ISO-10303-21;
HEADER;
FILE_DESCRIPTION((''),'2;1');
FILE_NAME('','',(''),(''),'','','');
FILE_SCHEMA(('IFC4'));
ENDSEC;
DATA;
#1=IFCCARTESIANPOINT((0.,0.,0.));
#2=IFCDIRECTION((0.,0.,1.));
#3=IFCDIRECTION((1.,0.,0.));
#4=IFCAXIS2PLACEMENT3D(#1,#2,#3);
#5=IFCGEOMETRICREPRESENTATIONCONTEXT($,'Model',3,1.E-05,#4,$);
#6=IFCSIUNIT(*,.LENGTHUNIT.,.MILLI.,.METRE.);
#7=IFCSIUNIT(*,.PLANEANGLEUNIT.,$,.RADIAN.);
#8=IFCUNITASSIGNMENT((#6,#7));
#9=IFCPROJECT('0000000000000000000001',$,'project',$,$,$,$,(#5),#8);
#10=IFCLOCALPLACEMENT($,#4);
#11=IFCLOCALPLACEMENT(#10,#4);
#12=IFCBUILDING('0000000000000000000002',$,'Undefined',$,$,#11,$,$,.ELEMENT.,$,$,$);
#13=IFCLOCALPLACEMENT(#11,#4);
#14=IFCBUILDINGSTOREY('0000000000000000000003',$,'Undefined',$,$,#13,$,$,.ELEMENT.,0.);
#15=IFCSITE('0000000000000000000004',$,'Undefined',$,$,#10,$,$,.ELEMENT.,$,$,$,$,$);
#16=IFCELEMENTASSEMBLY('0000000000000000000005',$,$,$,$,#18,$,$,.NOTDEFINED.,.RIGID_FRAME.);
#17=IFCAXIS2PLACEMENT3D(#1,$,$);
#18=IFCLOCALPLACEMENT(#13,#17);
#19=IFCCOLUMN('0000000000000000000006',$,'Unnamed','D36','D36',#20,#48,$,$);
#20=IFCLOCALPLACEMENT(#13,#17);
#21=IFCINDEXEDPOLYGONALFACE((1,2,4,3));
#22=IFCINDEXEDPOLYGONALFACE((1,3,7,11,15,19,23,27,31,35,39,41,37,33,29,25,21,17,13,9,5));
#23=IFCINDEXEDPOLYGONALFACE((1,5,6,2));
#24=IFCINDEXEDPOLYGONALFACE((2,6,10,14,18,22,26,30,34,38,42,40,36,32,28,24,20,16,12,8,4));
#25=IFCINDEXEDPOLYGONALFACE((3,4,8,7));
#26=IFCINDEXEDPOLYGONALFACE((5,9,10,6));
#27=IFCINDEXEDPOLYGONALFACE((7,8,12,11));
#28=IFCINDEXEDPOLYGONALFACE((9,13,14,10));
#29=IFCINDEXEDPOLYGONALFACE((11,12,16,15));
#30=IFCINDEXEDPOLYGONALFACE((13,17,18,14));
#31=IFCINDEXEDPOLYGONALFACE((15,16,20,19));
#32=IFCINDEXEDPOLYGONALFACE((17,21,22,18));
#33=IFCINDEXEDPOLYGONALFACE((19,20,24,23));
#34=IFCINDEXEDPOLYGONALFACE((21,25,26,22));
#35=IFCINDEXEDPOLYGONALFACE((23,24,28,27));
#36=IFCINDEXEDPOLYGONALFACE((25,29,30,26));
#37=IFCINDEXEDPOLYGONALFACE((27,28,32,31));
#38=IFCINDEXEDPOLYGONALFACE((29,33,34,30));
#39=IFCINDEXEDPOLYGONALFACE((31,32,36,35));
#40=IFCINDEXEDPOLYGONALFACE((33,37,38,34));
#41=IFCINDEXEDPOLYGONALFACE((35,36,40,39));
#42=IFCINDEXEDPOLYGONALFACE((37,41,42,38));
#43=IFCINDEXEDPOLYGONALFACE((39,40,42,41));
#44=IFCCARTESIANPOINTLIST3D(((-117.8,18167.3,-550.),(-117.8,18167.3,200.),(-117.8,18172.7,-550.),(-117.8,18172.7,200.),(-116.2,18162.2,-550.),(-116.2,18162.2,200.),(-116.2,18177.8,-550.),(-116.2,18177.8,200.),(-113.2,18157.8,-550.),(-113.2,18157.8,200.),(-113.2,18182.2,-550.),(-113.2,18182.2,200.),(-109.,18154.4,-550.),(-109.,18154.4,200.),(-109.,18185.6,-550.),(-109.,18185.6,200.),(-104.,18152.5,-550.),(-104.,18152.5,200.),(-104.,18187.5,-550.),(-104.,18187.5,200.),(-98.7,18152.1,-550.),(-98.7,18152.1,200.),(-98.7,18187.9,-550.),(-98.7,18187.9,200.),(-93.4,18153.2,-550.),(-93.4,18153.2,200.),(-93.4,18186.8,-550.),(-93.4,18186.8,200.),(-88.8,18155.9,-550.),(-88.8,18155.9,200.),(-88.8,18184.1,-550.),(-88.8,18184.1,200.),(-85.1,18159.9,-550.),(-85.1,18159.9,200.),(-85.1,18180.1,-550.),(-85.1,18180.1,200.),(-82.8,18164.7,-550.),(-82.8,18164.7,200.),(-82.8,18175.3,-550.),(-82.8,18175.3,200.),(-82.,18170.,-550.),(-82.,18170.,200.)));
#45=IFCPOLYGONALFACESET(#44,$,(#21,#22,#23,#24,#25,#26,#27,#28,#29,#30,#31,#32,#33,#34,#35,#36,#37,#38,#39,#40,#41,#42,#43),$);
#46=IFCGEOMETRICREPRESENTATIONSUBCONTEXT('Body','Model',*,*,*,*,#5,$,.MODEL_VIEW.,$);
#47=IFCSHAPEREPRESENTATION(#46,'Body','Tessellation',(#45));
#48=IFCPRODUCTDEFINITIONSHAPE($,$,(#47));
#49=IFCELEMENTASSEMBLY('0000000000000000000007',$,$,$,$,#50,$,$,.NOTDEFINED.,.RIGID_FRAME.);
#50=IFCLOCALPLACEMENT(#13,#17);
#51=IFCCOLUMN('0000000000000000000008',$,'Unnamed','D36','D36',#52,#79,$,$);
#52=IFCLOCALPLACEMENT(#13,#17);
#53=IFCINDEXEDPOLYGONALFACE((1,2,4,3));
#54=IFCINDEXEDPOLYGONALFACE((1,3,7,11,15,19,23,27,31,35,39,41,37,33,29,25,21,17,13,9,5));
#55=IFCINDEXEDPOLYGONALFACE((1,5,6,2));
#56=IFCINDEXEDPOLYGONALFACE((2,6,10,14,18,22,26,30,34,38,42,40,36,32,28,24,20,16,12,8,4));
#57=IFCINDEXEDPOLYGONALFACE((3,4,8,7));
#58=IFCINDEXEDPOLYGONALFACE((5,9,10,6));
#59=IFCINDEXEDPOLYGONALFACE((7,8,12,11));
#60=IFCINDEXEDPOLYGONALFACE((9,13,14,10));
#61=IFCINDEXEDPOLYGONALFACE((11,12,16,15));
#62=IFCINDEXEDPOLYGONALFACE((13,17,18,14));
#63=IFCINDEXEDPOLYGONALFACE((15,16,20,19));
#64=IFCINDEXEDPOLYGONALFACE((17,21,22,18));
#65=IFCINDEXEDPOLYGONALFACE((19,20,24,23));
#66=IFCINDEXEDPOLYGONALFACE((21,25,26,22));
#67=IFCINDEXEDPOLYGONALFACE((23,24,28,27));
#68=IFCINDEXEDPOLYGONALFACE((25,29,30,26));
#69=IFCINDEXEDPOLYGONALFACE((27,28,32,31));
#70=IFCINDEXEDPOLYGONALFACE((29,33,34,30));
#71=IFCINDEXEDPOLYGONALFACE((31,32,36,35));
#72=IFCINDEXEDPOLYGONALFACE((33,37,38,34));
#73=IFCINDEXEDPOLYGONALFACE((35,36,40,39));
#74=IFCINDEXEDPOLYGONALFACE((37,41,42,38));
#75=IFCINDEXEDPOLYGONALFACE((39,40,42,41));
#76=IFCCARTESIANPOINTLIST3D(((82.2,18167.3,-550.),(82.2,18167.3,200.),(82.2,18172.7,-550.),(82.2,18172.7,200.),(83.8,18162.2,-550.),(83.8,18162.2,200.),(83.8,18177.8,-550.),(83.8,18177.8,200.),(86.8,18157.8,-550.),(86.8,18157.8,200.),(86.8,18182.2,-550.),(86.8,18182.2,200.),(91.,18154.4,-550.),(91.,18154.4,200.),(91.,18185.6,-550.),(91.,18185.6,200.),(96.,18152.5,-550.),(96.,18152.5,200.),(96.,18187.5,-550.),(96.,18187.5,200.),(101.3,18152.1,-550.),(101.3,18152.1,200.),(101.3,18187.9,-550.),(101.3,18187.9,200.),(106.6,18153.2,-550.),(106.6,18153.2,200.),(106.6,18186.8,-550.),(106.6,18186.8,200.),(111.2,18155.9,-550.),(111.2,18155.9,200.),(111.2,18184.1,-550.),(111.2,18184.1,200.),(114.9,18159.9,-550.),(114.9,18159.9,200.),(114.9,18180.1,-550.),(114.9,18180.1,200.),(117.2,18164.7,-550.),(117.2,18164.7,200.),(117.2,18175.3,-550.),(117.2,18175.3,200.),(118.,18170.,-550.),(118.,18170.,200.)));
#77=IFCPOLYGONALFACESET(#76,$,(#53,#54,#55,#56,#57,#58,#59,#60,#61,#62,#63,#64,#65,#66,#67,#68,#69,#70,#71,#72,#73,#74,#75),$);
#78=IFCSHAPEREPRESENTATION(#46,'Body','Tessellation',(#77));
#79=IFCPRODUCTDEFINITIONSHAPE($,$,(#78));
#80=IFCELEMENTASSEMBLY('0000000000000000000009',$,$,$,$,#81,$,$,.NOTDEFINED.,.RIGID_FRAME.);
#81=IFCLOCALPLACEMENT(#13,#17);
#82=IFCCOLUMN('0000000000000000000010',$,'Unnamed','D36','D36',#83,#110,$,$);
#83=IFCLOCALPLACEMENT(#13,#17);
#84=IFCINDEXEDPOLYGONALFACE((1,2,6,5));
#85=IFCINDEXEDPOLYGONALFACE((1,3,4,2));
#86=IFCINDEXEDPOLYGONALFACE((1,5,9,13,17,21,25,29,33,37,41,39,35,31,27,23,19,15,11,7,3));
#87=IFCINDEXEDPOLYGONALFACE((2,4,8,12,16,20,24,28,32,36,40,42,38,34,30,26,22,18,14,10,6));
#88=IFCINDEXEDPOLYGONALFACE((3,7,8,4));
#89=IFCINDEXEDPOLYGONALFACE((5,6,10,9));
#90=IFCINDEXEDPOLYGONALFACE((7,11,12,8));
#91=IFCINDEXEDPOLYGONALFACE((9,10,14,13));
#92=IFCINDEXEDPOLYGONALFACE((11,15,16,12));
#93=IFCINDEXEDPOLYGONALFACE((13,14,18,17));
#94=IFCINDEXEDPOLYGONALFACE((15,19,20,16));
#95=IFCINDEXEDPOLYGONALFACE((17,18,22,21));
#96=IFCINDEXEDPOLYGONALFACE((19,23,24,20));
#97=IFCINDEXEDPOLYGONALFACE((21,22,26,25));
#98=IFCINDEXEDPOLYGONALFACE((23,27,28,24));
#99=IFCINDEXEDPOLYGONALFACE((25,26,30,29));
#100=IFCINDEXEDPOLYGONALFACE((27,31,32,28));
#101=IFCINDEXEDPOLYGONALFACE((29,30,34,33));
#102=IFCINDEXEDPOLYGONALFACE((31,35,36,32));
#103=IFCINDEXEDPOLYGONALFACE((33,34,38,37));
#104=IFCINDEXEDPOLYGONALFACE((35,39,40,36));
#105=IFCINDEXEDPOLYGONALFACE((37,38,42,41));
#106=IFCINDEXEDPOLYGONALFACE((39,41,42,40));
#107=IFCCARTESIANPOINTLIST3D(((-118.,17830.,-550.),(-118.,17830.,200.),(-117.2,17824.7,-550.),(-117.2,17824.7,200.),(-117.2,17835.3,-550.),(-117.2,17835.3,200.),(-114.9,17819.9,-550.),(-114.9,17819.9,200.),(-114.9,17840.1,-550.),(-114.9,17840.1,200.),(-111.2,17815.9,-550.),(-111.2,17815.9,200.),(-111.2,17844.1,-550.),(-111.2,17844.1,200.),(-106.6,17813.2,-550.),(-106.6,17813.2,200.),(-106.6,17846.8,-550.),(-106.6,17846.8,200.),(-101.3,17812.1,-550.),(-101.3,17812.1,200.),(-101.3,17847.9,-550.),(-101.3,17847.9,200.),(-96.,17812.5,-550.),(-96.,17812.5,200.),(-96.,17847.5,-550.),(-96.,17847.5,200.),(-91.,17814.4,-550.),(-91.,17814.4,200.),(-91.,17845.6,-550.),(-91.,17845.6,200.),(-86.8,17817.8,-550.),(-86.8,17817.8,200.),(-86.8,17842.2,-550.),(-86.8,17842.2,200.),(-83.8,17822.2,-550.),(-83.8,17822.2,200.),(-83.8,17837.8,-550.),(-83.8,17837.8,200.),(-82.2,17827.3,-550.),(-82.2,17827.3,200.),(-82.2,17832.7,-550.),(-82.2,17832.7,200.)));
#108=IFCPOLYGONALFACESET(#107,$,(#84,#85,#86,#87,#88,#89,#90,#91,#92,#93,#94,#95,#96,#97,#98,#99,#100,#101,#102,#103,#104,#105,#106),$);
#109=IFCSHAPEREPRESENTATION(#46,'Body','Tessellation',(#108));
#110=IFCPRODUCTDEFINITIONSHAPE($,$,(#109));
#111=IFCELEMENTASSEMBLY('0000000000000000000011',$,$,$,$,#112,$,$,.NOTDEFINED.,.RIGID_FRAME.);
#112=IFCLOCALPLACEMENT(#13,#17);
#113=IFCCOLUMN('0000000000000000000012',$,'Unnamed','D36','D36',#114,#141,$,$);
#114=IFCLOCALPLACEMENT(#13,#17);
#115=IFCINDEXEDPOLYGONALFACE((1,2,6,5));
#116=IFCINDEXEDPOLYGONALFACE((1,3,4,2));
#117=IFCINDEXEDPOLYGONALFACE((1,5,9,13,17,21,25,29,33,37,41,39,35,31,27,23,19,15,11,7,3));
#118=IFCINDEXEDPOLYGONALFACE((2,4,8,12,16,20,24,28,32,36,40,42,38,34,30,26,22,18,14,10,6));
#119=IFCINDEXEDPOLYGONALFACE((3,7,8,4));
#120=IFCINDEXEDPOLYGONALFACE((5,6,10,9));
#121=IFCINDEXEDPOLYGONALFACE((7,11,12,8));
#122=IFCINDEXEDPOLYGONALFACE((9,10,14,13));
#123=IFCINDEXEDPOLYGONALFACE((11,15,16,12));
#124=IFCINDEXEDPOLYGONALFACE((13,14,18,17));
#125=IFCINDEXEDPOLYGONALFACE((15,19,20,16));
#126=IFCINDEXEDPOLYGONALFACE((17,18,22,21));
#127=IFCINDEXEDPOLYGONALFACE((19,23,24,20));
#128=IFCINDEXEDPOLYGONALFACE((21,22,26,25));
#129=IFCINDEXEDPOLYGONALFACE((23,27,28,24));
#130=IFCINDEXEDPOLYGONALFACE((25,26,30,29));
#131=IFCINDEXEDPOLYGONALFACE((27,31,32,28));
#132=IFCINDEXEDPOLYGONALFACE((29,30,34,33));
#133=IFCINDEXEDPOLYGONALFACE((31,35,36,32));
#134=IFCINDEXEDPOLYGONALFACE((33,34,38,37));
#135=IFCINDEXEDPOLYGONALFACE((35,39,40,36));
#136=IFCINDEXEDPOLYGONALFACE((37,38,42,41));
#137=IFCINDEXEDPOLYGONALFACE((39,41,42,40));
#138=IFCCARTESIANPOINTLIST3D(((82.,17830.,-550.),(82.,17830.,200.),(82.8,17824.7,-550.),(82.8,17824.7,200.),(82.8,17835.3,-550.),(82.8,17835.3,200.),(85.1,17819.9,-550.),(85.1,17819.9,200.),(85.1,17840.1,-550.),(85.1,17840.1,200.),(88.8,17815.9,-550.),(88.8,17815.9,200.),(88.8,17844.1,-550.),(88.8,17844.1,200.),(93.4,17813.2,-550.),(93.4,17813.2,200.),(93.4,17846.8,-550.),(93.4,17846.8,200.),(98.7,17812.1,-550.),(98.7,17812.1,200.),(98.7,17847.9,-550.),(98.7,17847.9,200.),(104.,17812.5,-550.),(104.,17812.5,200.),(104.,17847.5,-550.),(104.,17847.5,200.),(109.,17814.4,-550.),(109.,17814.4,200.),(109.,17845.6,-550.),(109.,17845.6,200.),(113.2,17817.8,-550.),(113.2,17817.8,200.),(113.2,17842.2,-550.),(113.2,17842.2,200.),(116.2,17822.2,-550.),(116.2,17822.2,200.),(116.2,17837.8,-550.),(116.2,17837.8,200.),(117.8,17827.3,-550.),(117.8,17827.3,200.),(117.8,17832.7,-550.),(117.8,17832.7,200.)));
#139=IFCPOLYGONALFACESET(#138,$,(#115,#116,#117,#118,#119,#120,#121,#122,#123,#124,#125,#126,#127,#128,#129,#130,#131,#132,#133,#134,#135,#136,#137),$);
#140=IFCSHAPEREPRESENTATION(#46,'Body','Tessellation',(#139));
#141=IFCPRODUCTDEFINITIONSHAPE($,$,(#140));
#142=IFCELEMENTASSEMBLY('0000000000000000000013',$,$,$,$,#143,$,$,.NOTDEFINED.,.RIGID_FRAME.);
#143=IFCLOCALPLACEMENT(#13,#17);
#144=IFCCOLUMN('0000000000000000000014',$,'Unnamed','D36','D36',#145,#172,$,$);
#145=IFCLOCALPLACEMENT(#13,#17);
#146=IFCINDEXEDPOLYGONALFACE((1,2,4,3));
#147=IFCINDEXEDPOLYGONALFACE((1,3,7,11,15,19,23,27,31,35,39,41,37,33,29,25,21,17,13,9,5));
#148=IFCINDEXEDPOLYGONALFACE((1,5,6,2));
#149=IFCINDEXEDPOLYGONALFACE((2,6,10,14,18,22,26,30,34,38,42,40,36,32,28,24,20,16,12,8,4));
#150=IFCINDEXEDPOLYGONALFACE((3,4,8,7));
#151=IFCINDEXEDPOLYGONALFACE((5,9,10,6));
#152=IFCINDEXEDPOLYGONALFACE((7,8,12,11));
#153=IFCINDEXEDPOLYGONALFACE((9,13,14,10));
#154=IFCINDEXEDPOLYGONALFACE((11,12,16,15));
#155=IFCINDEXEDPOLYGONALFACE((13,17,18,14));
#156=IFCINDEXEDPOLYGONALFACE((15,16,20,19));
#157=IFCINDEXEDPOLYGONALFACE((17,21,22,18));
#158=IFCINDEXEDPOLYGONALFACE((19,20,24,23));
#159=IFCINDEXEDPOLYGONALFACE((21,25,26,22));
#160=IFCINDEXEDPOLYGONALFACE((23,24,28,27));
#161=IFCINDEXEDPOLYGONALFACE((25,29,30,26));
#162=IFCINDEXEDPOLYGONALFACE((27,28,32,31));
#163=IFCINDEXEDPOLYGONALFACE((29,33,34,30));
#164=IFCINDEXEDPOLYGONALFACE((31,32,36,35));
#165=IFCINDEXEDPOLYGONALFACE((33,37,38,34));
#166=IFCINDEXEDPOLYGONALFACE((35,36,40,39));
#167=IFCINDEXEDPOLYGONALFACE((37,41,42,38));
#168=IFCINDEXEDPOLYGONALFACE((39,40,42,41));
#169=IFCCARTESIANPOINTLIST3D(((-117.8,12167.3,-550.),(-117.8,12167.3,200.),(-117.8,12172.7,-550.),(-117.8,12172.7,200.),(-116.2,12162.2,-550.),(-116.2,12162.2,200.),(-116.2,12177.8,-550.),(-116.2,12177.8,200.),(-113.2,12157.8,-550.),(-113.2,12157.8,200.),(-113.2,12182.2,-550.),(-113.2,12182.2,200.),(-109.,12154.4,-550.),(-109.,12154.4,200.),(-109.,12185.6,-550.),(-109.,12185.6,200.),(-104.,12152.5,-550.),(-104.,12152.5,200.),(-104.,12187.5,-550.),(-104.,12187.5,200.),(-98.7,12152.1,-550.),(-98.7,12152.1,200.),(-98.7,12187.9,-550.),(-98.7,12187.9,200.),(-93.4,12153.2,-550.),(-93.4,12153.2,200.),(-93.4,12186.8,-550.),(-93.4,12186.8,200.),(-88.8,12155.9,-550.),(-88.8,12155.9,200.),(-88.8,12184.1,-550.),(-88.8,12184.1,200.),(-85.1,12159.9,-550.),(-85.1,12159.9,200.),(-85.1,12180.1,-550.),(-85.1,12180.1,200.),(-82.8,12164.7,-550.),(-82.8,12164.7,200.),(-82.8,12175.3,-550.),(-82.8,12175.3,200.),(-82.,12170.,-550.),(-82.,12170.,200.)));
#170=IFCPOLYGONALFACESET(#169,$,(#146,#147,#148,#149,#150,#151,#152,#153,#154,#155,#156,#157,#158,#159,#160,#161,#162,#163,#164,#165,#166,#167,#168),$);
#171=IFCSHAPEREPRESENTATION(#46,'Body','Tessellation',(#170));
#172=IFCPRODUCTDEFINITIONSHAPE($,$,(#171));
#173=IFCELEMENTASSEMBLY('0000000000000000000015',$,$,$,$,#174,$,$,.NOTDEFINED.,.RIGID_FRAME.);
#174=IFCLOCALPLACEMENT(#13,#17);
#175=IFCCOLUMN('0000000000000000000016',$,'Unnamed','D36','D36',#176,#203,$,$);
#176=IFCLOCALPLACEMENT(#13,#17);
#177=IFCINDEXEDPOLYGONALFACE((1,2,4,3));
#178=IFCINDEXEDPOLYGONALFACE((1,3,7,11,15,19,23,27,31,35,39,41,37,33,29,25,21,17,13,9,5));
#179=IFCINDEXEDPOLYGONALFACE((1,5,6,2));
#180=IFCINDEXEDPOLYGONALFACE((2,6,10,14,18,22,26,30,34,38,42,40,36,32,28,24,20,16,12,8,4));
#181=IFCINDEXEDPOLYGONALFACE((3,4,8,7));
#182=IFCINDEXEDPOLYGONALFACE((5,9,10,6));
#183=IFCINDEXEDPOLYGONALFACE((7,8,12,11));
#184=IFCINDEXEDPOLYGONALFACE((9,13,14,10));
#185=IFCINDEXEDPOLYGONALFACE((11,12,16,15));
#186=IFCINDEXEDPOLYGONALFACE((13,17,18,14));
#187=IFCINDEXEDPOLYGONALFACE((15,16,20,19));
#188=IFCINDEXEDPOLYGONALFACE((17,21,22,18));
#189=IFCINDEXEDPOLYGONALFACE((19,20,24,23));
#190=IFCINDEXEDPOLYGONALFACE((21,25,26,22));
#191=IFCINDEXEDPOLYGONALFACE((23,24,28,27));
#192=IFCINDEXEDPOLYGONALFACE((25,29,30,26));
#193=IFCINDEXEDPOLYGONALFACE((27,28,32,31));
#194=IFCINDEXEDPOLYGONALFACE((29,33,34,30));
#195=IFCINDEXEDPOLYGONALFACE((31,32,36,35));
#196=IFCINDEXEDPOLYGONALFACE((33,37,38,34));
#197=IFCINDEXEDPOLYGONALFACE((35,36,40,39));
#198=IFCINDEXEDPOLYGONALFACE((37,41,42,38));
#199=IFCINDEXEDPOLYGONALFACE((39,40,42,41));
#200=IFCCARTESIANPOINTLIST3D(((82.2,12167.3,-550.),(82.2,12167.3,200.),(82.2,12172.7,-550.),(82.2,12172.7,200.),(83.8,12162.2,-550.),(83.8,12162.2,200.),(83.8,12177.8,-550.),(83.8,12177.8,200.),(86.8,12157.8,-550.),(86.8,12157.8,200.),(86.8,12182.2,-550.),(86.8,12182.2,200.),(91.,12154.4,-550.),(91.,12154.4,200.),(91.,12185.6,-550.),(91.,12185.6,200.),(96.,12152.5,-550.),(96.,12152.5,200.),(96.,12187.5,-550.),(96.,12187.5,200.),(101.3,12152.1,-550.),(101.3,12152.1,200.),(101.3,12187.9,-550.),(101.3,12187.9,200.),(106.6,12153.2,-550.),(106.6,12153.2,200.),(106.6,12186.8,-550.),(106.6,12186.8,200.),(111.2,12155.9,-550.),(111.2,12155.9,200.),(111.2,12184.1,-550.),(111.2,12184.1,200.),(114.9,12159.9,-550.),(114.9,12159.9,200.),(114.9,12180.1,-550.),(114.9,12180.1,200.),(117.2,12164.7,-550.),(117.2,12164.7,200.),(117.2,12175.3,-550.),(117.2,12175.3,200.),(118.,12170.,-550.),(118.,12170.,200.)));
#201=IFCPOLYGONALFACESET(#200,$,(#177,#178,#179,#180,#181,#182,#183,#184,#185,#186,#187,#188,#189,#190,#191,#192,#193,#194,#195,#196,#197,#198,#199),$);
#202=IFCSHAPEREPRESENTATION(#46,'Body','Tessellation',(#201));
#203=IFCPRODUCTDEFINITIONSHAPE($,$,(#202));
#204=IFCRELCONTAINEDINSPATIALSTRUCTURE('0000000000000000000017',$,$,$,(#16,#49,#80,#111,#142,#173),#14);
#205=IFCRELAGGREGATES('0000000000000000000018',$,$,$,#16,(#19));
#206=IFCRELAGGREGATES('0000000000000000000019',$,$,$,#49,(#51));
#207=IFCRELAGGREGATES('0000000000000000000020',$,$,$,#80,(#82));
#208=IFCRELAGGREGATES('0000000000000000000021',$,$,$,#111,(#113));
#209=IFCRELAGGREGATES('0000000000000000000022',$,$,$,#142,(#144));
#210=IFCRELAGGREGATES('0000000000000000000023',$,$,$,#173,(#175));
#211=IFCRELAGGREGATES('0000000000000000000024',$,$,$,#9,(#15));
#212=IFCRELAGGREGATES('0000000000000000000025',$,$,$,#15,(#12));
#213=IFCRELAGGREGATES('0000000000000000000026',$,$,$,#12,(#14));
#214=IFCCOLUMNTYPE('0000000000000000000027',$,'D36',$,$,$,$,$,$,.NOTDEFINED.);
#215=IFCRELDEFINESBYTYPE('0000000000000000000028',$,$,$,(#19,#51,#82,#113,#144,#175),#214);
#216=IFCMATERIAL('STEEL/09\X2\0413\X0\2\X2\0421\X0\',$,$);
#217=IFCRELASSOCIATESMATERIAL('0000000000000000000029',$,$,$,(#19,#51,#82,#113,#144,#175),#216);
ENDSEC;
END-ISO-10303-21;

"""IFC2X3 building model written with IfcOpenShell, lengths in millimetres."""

from ifc_helpers import new_model, si_unit, frame, origin_with_axes, origin_2d_with_axis, place, context, subcontext, project, spatial, circle, extrude, material, type_object, element, aggregate, save


model = new_model("IFC2X3")

# Units and contexts
model_context = context("Model", 3, precision=1e-05, world=origin_with_axes())
body_context = subcontext(model_context, "Body", "Model", "MODEL_VIEW")
ifc_project = project(units=[si_unit("LENGTHUNIT", "METRE", prefix="MILLI"), si_unit("PLANEANGLEUNIT", "RADIAN")], contexts=[model_context])

# Site, building, storey
site_placement = place(None, origin_with_axes())
site = spatial("IfcSite", under=ifc_project, at=site_placement, Name="Undefined", CompositionType="ELEMENT")
building_placement = place(site_placement, origin_with_axes())
building = spatial("IfcBuilding", under=site, at=building_placement, Name="Undefined", CompositionType="ELEMENT")
storey_placement = place(building_placement, origin_with_axes())
storey = spatial("IfcBuildingStorey", under=building, at=storey_placement, Name="Undefined", CompositionType="ELEMENT", Elevation=0.0)

# Element assemblies, columns
assembly_1_placement = place(storey_placement, origin_with_axes())
assembly_1 = element("IfcElementAssembly", 1, at=assembly_1_placement, inside=storey, AssemblyPlace="NOTDEFINED", PredefinedType="RIGID_FRAME")
ifc_material_1 = material(Name="STEEL/09Г2С")
column_type_1 = type_object("IfcColumnType", Name="D36", PredefinedType="NOTDEFINED")
column_1_placement = place(assembly_1_placement, frame((-100.0, 18170.0, -550.0), z_axis=(0.0, 0.0, 1.0), x_axis=(0.0, -1.0, 0.0)))
column_1 = element("IfcColumn", 2, at=column_1_placement, type_object=column_type_1, material=ifc_material_1, Name="Unnamed", Description="D36", ObjectType="D36", context=body_context, shape_type="SweptSolid", body=[
    extrude(circle(Radius=18.0, at=origin_2d_with_axis()), frame((0.0, 0.0, 750.0), z_axis=(0.0, 0.0, -1.0), x_axis=(0.0, 1.0, 0.0)), (0.0, 0.0, 1.0), 750.0),
])
aggregate(assembly_1, [column_1])
assembly_2_placement = place(storey_placement, origin_with_axes())
assembly_2 = element("IfcElementAssembly", 3, at=assembly_2_placement, inside=storey, AssemblyPlace="NOTDEFINED", PredefinedType="RIGID_FRAME")
column_2_placement = place(assembly_2_placement, frame((100.0, 18170.0, -550.0), z_axis=(0.0, 0.0, 1.0), x_axis=(0.0, -1.0, 0.0)))
column_2 = element("IfcColumn", 4, at=column_2_placement, type_object=column_type_1, material=ifc_material_1, Name="Unnamed", Description="D36", ObjectType="D36", context=body_context, shape_type="SweptSolid", body=[
    extrude(circle(Radius=18.0, at=origin_2d_with_axis()), frame((0.0, 0.0, 750.0), z_axis=(0.0, 0.0, -1.0), x_axis=(0.0, 1.0, 0.0)), (0.0, 0.0, 1.0), 750.0),
])
aggregate(assembly_2, [column_2])
assembly_3_placement = place(storey_placement, origin_with_axes())
assembly_3 = element("IfcElementAssembly", 5, at=assembly_3_placement, inside=storey, AssemblyPlace="NOTDEFINED", PredefinedType="RIGID_FRAME")
column_3_placement = place(assembly_3_placement, frame((-100.0, 17830.0, -550.0), z_axis=(0.0, 0.0, 1.0), x_axis=(0.0, 1.0, 0.0)))
column_3 = element("IfcColumn", 6, at=column_3_placement, type_object=column_type_1, material=ifc_material_1, Name="Unnamed", Description="D36", ObjectType="D36", context=body_context, shape_type="SweptSolid", body=[
    extrude(circle(Radius=18.0, at=origin_2d_with_axis()), frame((0.0, 0.0, 750.0), z_axis=(0.0, 0.0, -1.0), x_axis=(0.0, 1.0, 0.0)), (0.0, 0.0, 1.0), 750.0),
])
aggregate(assembly_3, [column_3])
assembly_4_placement = place(storey_placement, origin_with_axes())
assembly_4 = element("IfcElementAssembly", 7, at=assembly_4_placement, inside=storey, AssemblyPlace="NOTDEFINED", PredefinedType="RIGID_FRAME")
column_4_placement = place(assembly_4_placement, frame((100.0, 17830.0, -550.0), z_axis=(0.0, 0.0, 1.0), x_axis=(0.0, 1.0, 0.0)))
column_4 = element("IfcColumn", 8, at=column_4_placement, type_object=column_type_1, material=ifc_material_1, Name="Unnamed", Description="D36", ObjectType="D36", context=body_context, shape_type="SweptSolid", body=[
    extrude(circle(Radius=18.0, at=origin_2d_with_axis()), frame((0.0, 0.0, 750.0), z_axis=(0.0, 0.0, -1.0), x_axis=(0.0, 1.0, 0.0)), (0.0, 0.0, 1.0), 750.0),
])
aggregate(assembly_4, [column_4])
assembly_5_placement = place(storey_placement, origin_with_axes())
assembly_5 = element("IfcElementAssembly", 9, at=assembly_5_placement, inside=storey, AssemblyPlace="NOTDEFINED", PredefinedType="RIGID_FRAME")
column_5_placement = place(assembly_5_placement, frame((-100.0, 12170.0, -550.0), z_axis=(0.0, 0.0, 1.0), x_axis=(0.0, -1.0, 0.0)))
column_5 = element("IfcColumn", 10, at=column_5_placement, type_object=column_type_1, material=ifc_material_1, Name="Unnamed", Description="D36", ObjectType="D36", context=body_context, shape_type="SweptSolid", body=[
    extrude(circle(Radius=18.0, at=origin_2d_with_axis()), frame((0.0, 0.0, 750.0), z_axis=(0.0, 0.0, -1.0), x_axis=(0.0, 1.0, 0.0)), (0.0, 0.0, 1.0), 750.0),
])
aggregate(assembly_5, [column_5])
assembly_6_placement = place(storey_placement, origin_with_axes())
assembly_6 = element("IfcElementAssembly", 11, at=assembly_6_placement, inside=storey, AssemblyPlace="NOTDEFINED", PredefinedType="RIGID_FRAME")
column_6_placement = place(assembly_6_placement, frame((100.0, 12170.0, -550.0), z_axis=(0.0, 0.0, 1.0), x_axis=(0.0, -1.0, 0.0)))
column_6 = element("IfcColumn", 12, at=column_6_placement, type_object=column_type_1, material=ifc_material_1, Name="Unnamed", Description="D36", ObjectType="D36", context=body_context, shape_type="SweptSolid", body=[
    extrude(circle(Radius=18.0, at=origin_2d_with_axis()), frame((0.0, 0.0, 750.0), z_axis=(0.0, 0.0, -1.0), x_axis=(0.0, 1.0, 0.0)), (0.0, 0.0, 1.0), 750.0),
])
aggregate(assembly_6, [column_6])

save(model, "model.ifc")
